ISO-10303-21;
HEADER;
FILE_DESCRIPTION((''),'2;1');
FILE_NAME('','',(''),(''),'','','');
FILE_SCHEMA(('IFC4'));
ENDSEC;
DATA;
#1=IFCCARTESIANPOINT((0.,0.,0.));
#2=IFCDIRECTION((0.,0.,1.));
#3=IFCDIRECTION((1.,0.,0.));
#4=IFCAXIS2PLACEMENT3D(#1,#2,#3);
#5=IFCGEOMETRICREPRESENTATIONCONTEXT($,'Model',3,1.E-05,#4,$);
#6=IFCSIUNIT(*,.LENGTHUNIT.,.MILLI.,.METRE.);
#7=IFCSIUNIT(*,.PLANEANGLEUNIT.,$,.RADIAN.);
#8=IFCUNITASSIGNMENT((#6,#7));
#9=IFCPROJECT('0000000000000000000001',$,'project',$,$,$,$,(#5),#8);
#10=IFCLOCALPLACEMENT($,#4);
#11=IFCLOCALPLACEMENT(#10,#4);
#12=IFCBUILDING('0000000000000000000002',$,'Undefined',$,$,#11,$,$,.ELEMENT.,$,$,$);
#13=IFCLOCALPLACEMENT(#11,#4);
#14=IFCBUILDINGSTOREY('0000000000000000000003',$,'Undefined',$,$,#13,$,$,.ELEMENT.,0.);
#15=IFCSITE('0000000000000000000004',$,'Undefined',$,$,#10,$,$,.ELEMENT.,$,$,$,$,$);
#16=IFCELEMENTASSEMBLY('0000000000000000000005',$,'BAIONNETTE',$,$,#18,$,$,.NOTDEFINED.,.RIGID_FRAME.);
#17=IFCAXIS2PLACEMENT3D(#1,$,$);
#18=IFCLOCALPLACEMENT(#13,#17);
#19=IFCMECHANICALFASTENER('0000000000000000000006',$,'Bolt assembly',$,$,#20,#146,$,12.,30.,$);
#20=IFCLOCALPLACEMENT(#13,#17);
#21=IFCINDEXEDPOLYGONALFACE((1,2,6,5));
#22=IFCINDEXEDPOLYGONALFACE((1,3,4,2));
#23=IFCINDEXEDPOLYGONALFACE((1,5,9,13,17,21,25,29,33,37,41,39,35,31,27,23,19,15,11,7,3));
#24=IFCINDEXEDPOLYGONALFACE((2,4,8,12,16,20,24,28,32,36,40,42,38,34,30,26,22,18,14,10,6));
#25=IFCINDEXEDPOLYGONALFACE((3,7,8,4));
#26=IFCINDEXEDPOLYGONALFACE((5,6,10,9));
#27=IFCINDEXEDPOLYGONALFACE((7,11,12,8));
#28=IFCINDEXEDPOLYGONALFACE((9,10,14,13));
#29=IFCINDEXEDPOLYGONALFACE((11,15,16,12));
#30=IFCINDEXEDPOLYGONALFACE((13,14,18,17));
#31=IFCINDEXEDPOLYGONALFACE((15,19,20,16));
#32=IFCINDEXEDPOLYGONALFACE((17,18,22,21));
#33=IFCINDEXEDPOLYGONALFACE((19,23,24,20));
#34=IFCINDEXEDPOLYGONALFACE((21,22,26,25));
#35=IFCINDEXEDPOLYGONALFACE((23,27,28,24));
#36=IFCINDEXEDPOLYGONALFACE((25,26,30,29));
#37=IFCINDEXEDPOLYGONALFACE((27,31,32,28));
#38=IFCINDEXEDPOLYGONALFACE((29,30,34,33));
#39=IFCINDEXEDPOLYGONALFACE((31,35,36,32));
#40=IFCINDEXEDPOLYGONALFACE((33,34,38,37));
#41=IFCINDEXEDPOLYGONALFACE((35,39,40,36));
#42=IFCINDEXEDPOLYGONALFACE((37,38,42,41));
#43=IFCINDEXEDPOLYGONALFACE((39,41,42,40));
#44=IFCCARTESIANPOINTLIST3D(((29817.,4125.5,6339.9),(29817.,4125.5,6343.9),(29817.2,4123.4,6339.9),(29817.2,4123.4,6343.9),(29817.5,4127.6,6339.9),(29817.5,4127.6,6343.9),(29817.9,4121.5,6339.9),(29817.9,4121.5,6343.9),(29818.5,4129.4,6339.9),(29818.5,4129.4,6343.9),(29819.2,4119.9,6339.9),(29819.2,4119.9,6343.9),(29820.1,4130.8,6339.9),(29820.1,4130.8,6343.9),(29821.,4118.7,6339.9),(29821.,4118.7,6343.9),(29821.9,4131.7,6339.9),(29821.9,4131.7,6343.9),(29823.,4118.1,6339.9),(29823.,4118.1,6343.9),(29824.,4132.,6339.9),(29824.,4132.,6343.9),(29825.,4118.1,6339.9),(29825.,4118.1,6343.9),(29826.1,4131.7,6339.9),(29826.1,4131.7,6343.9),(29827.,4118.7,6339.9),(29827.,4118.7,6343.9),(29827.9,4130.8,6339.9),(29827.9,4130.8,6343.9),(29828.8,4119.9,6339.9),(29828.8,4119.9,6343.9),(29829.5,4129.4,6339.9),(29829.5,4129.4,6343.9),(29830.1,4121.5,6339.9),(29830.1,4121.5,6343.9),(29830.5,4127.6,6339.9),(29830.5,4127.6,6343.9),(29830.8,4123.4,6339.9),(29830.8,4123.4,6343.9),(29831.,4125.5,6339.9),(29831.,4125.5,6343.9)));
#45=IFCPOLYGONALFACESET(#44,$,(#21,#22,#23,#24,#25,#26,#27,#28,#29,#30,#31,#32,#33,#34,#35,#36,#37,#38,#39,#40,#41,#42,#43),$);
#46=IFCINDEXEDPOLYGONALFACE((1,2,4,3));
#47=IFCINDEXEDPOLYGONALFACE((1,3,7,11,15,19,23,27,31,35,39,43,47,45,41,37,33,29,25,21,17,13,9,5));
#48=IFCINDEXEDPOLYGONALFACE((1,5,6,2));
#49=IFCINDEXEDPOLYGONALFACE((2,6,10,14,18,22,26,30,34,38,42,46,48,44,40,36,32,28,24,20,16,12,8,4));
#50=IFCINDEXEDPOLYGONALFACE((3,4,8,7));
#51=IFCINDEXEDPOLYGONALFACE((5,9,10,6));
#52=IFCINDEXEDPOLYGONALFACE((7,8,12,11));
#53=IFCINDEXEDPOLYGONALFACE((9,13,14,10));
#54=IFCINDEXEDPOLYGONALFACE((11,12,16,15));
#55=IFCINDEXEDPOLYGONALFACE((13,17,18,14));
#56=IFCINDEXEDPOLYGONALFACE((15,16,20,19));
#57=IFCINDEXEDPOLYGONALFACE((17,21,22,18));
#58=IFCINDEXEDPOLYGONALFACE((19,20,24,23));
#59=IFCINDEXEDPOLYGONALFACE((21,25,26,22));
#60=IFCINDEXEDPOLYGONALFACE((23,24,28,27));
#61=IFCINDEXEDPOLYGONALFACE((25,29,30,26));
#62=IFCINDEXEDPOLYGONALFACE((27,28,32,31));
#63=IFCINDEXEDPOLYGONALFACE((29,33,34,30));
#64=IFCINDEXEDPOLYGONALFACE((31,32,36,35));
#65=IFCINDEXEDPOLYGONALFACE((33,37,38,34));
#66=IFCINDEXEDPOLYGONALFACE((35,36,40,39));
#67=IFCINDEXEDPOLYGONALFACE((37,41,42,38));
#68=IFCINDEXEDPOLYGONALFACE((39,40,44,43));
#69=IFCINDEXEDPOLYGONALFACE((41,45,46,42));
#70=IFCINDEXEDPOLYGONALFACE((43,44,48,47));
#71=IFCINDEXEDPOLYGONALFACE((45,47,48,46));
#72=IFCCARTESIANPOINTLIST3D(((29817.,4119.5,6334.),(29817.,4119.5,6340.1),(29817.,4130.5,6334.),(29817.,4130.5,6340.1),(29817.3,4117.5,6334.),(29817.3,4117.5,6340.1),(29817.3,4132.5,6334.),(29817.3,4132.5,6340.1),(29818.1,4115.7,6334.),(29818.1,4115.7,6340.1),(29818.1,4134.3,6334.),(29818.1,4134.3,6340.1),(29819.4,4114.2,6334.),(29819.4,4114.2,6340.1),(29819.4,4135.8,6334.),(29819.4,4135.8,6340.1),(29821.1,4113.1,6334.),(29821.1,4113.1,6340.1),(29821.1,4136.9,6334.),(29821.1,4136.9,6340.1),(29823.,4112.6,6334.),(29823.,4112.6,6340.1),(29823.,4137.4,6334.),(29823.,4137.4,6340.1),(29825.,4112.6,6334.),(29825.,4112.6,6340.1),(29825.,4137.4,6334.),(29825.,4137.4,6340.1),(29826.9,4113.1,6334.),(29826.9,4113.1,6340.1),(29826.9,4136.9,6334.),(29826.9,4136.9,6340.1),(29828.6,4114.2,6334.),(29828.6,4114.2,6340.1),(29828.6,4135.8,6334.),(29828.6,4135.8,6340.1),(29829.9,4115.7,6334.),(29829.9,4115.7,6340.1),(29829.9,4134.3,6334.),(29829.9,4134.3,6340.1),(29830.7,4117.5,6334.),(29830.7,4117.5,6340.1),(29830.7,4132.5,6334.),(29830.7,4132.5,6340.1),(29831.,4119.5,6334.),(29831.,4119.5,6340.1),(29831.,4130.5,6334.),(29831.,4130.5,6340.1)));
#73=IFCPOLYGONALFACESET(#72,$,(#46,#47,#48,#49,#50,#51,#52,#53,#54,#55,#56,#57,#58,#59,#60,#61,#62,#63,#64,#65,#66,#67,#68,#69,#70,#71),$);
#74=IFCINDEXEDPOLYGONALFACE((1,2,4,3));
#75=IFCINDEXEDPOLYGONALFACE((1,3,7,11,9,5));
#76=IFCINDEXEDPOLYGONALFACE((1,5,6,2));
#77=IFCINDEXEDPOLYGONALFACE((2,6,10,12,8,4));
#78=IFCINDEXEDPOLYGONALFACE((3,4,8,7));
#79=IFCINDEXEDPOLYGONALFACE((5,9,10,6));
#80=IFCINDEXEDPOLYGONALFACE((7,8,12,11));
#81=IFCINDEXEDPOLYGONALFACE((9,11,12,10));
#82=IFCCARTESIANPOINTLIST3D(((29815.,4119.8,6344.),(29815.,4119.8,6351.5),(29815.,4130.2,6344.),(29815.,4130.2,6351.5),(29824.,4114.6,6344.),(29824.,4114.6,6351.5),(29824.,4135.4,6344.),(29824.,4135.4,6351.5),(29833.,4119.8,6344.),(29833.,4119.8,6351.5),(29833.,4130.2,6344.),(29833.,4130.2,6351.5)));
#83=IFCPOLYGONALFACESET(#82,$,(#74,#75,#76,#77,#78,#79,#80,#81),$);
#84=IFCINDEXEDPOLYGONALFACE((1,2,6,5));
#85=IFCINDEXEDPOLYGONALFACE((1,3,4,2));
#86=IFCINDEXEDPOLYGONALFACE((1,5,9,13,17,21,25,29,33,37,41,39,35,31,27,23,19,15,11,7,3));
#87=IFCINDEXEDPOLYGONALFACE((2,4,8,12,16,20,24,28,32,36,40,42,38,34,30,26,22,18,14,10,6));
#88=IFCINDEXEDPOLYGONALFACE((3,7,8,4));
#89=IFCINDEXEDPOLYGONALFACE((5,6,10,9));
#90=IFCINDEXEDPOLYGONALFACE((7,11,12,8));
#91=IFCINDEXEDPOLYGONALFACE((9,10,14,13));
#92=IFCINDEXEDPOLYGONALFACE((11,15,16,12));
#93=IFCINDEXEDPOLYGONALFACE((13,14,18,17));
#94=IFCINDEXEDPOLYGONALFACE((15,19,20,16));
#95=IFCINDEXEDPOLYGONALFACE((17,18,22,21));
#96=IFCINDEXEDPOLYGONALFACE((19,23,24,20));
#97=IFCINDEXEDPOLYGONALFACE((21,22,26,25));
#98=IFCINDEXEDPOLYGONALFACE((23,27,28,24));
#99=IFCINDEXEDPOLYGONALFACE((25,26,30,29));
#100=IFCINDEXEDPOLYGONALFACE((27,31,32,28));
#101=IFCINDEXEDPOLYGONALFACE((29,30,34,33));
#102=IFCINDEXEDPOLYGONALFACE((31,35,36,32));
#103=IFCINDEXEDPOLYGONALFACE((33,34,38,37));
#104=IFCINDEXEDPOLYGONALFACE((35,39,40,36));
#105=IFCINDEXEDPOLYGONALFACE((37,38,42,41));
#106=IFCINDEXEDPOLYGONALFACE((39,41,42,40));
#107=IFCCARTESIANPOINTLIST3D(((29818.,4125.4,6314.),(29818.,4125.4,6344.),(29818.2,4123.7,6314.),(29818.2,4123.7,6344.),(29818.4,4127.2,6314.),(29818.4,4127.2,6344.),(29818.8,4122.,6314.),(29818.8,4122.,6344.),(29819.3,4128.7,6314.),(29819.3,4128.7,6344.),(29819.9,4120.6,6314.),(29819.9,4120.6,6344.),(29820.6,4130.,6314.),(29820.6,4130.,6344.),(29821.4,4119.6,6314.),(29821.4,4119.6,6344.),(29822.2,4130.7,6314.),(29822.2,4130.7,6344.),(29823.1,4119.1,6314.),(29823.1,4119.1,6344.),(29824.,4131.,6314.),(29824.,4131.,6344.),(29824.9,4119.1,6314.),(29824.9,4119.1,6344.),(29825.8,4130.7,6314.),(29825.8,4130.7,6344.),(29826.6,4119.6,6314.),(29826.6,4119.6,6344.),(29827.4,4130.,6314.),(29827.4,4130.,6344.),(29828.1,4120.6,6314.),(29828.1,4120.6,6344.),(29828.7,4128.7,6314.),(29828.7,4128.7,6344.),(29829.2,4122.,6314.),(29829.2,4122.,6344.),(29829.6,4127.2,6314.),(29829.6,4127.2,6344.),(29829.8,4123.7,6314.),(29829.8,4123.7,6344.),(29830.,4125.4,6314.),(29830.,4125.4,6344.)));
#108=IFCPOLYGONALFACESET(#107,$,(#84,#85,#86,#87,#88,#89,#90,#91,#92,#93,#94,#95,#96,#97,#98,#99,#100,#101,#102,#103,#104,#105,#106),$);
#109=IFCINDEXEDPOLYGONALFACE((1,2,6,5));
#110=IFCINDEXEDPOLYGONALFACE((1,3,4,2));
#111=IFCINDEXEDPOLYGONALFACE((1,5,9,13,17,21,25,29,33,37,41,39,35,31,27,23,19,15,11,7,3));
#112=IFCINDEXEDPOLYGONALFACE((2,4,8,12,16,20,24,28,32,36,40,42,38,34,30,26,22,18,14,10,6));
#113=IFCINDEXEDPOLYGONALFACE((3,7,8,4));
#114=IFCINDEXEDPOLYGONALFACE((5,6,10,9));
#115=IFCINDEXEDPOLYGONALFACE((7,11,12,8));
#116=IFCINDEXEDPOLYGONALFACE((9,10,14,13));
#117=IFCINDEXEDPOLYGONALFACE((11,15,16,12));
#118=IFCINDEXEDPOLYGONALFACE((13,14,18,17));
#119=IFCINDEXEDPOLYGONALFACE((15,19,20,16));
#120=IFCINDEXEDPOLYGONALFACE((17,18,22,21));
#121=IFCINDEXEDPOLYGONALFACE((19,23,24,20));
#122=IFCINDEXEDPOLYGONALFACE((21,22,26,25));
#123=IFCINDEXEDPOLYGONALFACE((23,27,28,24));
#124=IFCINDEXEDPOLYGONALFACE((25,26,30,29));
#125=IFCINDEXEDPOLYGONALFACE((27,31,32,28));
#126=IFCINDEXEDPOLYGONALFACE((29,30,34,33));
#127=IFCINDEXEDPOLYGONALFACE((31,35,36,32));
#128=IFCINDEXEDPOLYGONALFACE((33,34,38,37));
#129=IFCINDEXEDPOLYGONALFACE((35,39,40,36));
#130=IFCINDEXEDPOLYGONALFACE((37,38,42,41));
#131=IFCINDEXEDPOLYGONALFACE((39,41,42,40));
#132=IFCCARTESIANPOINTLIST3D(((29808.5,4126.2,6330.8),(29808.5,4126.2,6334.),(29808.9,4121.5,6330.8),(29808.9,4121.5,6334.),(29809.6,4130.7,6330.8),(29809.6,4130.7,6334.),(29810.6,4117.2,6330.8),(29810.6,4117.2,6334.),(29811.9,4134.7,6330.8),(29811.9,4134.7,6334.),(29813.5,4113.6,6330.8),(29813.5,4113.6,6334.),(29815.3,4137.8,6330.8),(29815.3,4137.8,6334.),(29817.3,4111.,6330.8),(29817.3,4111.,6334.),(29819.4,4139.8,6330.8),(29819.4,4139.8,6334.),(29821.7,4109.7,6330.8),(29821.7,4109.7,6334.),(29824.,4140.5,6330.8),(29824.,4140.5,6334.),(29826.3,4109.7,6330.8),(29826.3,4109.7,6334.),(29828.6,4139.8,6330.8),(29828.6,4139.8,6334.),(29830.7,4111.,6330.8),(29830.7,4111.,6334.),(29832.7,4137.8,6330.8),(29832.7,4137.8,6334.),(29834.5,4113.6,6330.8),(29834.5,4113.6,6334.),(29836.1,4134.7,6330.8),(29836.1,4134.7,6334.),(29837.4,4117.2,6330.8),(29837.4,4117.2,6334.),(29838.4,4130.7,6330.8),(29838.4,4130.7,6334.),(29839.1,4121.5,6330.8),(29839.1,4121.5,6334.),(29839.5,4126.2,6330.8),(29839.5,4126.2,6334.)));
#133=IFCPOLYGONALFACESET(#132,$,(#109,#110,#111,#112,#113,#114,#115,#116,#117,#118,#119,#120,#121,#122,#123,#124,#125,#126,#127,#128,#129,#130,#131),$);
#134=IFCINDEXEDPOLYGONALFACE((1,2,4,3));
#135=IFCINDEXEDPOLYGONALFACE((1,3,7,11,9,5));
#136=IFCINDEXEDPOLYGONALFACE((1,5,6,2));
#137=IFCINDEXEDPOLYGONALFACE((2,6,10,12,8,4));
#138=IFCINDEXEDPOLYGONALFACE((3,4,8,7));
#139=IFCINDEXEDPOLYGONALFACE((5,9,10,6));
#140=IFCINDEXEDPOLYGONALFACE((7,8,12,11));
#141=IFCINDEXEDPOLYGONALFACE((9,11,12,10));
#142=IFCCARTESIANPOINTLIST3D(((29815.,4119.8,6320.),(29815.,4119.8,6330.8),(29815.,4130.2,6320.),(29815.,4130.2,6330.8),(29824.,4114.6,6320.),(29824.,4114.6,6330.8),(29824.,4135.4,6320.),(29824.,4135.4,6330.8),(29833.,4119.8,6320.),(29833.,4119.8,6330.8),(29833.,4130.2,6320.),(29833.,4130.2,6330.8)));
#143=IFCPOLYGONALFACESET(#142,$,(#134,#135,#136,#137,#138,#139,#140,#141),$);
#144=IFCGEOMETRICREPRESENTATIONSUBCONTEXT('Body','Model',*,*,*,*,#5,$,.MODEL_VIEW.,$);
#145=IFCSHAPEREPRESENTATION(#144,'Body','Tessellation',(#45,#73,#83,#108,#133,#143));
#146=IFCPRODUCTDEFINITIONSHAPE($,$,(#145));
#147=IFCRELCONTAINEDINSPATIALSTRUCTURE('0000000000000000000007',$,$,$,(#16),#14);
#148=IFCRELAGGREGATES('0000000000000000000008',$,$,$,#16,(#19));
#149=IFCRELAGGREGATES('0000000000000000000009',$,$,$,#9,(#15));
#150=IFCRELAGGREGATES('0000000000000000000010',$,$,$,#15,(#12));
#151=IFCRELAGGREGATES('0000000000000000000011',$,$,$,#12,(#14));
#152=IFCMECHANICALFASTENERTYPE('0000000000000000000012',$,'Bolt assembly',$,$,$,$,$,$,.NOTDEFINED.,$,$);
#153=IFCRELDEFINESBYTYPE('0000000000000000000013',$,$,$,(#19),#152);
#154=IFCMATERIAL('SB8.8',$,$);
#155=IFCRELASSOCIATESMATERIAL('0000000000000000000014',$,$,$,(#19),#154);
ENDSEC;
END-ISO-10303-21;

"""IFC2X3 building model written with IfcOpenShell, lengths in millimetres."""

from ifc_helpers import new_model, si_unit, frame, frame_2d, origin_with_axes, origin_2d_with_axis, place, context, subcontext, project, spatial, polyline, circle_curve, parameter, trimmed, segment, composite_curve, circle, outline, extrude, source, transform, mapped, material, type_object, element, aggregate, save


model = new_model("IFC2X3")

# Units and contexts
model_context = context("Model", 3, precision=1e-05, world=origin_with_axes())
body_context = subcontext(model_context, "Body", "Model", "MODEL_VIEW")
ifc_project = project(units=[si_unit("LENGTHUNIT", "METRE", prefix="MILLI"), si_unit("PLANEANGLEUNIT", "RADIAN")], contexts=[model_context])

# Site, building, storey
site_placement = place(None, origin_with_axes())
site = spatial("IfcSite", under=ifc_project, at=site_placement, Name="Undefined", CompositionType="ELEMENT")
building_placement = place(site_placement, origin_with_axes())
building = spatial("IfcBuilding", under=site, at=building_placement, Name="Undefined", CompositionType="ELEMENT")
storey_placement = place(building_placement, origin_with_axes())
storey = spatial("IfcBuildingStorey", under=building, at=storey_placement, Name="Undefined", CompositionType="ELEMENT", Elevation=0.0)

# Element assembly
assembly_1_placement = place(storey_placement, origin_with_axes())
assembly_1 = element("IfcElementAssembly", 1, at=assembly_1_placement, inside=storey, Name="BAIONNETTE", AssemblyPlace="NOTDEFINED", PredefinedType="RIGID_FRAME")

# Shared definitions
ifc_material_1 = material(Name="SB8.8")
mechanical_fastener_type = type_object("IfcMechanicalFastenerType", Name="Bolt assembly")

# Mechanical fastener
shared_shape_1 = source(origin_with_axes(), body_context, "Body", "SweptSolid", [
    extrude(circle(Radius=7.0, at=origin_2d_with_axis()), frame((0.0, -3.9, 0.0), z_axis=(0.0, 1.0, 0.0), x_axis=(1.0, 0.0, 0.0)), (0.0, 0.0, 1.0), 4.0),
    extrude(outline(composite_curve([segment(polyline([(-5.5, 7.0), (5.5, 7.0)]), True, "CONTINUOUS"), segment(trimmed(circle_curve(frame_2d((5.5, 0.0), x_axis=(0.0, 1.0)), 7.0), [parameter(0.0)], [parameter(3.141593)], False, "PARAMETER"), True, "CONTINUOUS"), segment(polyline([(5.5, -7.0), (-5.5, -7.0)]), True, "CONTINUOUS"), segment(trimmed(circle_curve(frame_2d((-5.5, 0.0), x_axis=(0.0, -1.0)), 7.0), [parameter(0.0)], [parameter(3.141593)], False, "PARAMETER"), True, "DISCONTINUOUS")], self_intersect=False)), frame((0.0, -0.1, 0.0), z_axis=(0.0, 1.0, 0.0), x_axis=(1.0, 0.0, 0.0)), (0.0, 0.0, 1.0), 6.1),
    extrude(outline(polyline([(10.4, 0.0), (5.2, 9.0), (-5.2, 9.0), (-10.4, 0.0), (-5.2, -9.0), (5.2, -9.0), (10.4, 0.0)])), frame((0.0, -11.5, 0.0), z_axis=(0.0, 1.0, 0.0), x_axis=(1.0, 0.0, 0.0)), (0.0, 0.0, 1.0), 7.5),
    extrude(circle(Radius=6.0, at=origin_2d_with_axis()), frame((0.0, -4.0, 0.0), z_axis=(0.0, 1.0, 0.0), x_axis=(1.0, 0.0, 0.0)), (0.0, 0.0, 1.0), 30.0),
    extrude(circle(Radius=15.5, at=origin_2d_with_axis()), frame((0.0, 6.0, 0.0), z_axis=(0.0, 1.0, 0.0), x_axis=(1.0, 0.0, 0.0)), (0.0, 0.0, 1.0), 3.2),
    extrude(outline(polyline([(10.4, 0.0), (5.2, 9.0), (-5.2, 9.0), (-10.4, 0.0), (-5.2, -9.0), (5.2, -9.0), (10.4, 0.0)])), frame((0.0, 9.2, 0.0), z_axis=(0.0, 1.0, 0.0), x_axis=(1.0, 0.0, 0.0)), (0.0, 0.0, 1.0), 10.8),
])
mechanical_fastener_1_placement = place(assembly_1_placement, frame((29824.0, 4125.0, 6340.0), z_axis=(-1.0, 0.0, 0.0), x_axis=(0.0, 1.0, 0.0)))
mechanical_fastener_1 = element("IfcMechanicalFastener", 2, at=mechanical_fastener_1_placement, type_object=mechanical_fastener_type, material=ifc_material_1, Name="Bolt assembly", NominalDiameter=12.0, NominalLength=30.0, context=body_context, shape_type="MappedRepresentation", body=[
    mapped(shared_shape_1, transform((0.0, 0.0, 0.0))),
])
aggregate(assembly_1, [mechanical_fastener_1])

save(model, "model.ifc")
